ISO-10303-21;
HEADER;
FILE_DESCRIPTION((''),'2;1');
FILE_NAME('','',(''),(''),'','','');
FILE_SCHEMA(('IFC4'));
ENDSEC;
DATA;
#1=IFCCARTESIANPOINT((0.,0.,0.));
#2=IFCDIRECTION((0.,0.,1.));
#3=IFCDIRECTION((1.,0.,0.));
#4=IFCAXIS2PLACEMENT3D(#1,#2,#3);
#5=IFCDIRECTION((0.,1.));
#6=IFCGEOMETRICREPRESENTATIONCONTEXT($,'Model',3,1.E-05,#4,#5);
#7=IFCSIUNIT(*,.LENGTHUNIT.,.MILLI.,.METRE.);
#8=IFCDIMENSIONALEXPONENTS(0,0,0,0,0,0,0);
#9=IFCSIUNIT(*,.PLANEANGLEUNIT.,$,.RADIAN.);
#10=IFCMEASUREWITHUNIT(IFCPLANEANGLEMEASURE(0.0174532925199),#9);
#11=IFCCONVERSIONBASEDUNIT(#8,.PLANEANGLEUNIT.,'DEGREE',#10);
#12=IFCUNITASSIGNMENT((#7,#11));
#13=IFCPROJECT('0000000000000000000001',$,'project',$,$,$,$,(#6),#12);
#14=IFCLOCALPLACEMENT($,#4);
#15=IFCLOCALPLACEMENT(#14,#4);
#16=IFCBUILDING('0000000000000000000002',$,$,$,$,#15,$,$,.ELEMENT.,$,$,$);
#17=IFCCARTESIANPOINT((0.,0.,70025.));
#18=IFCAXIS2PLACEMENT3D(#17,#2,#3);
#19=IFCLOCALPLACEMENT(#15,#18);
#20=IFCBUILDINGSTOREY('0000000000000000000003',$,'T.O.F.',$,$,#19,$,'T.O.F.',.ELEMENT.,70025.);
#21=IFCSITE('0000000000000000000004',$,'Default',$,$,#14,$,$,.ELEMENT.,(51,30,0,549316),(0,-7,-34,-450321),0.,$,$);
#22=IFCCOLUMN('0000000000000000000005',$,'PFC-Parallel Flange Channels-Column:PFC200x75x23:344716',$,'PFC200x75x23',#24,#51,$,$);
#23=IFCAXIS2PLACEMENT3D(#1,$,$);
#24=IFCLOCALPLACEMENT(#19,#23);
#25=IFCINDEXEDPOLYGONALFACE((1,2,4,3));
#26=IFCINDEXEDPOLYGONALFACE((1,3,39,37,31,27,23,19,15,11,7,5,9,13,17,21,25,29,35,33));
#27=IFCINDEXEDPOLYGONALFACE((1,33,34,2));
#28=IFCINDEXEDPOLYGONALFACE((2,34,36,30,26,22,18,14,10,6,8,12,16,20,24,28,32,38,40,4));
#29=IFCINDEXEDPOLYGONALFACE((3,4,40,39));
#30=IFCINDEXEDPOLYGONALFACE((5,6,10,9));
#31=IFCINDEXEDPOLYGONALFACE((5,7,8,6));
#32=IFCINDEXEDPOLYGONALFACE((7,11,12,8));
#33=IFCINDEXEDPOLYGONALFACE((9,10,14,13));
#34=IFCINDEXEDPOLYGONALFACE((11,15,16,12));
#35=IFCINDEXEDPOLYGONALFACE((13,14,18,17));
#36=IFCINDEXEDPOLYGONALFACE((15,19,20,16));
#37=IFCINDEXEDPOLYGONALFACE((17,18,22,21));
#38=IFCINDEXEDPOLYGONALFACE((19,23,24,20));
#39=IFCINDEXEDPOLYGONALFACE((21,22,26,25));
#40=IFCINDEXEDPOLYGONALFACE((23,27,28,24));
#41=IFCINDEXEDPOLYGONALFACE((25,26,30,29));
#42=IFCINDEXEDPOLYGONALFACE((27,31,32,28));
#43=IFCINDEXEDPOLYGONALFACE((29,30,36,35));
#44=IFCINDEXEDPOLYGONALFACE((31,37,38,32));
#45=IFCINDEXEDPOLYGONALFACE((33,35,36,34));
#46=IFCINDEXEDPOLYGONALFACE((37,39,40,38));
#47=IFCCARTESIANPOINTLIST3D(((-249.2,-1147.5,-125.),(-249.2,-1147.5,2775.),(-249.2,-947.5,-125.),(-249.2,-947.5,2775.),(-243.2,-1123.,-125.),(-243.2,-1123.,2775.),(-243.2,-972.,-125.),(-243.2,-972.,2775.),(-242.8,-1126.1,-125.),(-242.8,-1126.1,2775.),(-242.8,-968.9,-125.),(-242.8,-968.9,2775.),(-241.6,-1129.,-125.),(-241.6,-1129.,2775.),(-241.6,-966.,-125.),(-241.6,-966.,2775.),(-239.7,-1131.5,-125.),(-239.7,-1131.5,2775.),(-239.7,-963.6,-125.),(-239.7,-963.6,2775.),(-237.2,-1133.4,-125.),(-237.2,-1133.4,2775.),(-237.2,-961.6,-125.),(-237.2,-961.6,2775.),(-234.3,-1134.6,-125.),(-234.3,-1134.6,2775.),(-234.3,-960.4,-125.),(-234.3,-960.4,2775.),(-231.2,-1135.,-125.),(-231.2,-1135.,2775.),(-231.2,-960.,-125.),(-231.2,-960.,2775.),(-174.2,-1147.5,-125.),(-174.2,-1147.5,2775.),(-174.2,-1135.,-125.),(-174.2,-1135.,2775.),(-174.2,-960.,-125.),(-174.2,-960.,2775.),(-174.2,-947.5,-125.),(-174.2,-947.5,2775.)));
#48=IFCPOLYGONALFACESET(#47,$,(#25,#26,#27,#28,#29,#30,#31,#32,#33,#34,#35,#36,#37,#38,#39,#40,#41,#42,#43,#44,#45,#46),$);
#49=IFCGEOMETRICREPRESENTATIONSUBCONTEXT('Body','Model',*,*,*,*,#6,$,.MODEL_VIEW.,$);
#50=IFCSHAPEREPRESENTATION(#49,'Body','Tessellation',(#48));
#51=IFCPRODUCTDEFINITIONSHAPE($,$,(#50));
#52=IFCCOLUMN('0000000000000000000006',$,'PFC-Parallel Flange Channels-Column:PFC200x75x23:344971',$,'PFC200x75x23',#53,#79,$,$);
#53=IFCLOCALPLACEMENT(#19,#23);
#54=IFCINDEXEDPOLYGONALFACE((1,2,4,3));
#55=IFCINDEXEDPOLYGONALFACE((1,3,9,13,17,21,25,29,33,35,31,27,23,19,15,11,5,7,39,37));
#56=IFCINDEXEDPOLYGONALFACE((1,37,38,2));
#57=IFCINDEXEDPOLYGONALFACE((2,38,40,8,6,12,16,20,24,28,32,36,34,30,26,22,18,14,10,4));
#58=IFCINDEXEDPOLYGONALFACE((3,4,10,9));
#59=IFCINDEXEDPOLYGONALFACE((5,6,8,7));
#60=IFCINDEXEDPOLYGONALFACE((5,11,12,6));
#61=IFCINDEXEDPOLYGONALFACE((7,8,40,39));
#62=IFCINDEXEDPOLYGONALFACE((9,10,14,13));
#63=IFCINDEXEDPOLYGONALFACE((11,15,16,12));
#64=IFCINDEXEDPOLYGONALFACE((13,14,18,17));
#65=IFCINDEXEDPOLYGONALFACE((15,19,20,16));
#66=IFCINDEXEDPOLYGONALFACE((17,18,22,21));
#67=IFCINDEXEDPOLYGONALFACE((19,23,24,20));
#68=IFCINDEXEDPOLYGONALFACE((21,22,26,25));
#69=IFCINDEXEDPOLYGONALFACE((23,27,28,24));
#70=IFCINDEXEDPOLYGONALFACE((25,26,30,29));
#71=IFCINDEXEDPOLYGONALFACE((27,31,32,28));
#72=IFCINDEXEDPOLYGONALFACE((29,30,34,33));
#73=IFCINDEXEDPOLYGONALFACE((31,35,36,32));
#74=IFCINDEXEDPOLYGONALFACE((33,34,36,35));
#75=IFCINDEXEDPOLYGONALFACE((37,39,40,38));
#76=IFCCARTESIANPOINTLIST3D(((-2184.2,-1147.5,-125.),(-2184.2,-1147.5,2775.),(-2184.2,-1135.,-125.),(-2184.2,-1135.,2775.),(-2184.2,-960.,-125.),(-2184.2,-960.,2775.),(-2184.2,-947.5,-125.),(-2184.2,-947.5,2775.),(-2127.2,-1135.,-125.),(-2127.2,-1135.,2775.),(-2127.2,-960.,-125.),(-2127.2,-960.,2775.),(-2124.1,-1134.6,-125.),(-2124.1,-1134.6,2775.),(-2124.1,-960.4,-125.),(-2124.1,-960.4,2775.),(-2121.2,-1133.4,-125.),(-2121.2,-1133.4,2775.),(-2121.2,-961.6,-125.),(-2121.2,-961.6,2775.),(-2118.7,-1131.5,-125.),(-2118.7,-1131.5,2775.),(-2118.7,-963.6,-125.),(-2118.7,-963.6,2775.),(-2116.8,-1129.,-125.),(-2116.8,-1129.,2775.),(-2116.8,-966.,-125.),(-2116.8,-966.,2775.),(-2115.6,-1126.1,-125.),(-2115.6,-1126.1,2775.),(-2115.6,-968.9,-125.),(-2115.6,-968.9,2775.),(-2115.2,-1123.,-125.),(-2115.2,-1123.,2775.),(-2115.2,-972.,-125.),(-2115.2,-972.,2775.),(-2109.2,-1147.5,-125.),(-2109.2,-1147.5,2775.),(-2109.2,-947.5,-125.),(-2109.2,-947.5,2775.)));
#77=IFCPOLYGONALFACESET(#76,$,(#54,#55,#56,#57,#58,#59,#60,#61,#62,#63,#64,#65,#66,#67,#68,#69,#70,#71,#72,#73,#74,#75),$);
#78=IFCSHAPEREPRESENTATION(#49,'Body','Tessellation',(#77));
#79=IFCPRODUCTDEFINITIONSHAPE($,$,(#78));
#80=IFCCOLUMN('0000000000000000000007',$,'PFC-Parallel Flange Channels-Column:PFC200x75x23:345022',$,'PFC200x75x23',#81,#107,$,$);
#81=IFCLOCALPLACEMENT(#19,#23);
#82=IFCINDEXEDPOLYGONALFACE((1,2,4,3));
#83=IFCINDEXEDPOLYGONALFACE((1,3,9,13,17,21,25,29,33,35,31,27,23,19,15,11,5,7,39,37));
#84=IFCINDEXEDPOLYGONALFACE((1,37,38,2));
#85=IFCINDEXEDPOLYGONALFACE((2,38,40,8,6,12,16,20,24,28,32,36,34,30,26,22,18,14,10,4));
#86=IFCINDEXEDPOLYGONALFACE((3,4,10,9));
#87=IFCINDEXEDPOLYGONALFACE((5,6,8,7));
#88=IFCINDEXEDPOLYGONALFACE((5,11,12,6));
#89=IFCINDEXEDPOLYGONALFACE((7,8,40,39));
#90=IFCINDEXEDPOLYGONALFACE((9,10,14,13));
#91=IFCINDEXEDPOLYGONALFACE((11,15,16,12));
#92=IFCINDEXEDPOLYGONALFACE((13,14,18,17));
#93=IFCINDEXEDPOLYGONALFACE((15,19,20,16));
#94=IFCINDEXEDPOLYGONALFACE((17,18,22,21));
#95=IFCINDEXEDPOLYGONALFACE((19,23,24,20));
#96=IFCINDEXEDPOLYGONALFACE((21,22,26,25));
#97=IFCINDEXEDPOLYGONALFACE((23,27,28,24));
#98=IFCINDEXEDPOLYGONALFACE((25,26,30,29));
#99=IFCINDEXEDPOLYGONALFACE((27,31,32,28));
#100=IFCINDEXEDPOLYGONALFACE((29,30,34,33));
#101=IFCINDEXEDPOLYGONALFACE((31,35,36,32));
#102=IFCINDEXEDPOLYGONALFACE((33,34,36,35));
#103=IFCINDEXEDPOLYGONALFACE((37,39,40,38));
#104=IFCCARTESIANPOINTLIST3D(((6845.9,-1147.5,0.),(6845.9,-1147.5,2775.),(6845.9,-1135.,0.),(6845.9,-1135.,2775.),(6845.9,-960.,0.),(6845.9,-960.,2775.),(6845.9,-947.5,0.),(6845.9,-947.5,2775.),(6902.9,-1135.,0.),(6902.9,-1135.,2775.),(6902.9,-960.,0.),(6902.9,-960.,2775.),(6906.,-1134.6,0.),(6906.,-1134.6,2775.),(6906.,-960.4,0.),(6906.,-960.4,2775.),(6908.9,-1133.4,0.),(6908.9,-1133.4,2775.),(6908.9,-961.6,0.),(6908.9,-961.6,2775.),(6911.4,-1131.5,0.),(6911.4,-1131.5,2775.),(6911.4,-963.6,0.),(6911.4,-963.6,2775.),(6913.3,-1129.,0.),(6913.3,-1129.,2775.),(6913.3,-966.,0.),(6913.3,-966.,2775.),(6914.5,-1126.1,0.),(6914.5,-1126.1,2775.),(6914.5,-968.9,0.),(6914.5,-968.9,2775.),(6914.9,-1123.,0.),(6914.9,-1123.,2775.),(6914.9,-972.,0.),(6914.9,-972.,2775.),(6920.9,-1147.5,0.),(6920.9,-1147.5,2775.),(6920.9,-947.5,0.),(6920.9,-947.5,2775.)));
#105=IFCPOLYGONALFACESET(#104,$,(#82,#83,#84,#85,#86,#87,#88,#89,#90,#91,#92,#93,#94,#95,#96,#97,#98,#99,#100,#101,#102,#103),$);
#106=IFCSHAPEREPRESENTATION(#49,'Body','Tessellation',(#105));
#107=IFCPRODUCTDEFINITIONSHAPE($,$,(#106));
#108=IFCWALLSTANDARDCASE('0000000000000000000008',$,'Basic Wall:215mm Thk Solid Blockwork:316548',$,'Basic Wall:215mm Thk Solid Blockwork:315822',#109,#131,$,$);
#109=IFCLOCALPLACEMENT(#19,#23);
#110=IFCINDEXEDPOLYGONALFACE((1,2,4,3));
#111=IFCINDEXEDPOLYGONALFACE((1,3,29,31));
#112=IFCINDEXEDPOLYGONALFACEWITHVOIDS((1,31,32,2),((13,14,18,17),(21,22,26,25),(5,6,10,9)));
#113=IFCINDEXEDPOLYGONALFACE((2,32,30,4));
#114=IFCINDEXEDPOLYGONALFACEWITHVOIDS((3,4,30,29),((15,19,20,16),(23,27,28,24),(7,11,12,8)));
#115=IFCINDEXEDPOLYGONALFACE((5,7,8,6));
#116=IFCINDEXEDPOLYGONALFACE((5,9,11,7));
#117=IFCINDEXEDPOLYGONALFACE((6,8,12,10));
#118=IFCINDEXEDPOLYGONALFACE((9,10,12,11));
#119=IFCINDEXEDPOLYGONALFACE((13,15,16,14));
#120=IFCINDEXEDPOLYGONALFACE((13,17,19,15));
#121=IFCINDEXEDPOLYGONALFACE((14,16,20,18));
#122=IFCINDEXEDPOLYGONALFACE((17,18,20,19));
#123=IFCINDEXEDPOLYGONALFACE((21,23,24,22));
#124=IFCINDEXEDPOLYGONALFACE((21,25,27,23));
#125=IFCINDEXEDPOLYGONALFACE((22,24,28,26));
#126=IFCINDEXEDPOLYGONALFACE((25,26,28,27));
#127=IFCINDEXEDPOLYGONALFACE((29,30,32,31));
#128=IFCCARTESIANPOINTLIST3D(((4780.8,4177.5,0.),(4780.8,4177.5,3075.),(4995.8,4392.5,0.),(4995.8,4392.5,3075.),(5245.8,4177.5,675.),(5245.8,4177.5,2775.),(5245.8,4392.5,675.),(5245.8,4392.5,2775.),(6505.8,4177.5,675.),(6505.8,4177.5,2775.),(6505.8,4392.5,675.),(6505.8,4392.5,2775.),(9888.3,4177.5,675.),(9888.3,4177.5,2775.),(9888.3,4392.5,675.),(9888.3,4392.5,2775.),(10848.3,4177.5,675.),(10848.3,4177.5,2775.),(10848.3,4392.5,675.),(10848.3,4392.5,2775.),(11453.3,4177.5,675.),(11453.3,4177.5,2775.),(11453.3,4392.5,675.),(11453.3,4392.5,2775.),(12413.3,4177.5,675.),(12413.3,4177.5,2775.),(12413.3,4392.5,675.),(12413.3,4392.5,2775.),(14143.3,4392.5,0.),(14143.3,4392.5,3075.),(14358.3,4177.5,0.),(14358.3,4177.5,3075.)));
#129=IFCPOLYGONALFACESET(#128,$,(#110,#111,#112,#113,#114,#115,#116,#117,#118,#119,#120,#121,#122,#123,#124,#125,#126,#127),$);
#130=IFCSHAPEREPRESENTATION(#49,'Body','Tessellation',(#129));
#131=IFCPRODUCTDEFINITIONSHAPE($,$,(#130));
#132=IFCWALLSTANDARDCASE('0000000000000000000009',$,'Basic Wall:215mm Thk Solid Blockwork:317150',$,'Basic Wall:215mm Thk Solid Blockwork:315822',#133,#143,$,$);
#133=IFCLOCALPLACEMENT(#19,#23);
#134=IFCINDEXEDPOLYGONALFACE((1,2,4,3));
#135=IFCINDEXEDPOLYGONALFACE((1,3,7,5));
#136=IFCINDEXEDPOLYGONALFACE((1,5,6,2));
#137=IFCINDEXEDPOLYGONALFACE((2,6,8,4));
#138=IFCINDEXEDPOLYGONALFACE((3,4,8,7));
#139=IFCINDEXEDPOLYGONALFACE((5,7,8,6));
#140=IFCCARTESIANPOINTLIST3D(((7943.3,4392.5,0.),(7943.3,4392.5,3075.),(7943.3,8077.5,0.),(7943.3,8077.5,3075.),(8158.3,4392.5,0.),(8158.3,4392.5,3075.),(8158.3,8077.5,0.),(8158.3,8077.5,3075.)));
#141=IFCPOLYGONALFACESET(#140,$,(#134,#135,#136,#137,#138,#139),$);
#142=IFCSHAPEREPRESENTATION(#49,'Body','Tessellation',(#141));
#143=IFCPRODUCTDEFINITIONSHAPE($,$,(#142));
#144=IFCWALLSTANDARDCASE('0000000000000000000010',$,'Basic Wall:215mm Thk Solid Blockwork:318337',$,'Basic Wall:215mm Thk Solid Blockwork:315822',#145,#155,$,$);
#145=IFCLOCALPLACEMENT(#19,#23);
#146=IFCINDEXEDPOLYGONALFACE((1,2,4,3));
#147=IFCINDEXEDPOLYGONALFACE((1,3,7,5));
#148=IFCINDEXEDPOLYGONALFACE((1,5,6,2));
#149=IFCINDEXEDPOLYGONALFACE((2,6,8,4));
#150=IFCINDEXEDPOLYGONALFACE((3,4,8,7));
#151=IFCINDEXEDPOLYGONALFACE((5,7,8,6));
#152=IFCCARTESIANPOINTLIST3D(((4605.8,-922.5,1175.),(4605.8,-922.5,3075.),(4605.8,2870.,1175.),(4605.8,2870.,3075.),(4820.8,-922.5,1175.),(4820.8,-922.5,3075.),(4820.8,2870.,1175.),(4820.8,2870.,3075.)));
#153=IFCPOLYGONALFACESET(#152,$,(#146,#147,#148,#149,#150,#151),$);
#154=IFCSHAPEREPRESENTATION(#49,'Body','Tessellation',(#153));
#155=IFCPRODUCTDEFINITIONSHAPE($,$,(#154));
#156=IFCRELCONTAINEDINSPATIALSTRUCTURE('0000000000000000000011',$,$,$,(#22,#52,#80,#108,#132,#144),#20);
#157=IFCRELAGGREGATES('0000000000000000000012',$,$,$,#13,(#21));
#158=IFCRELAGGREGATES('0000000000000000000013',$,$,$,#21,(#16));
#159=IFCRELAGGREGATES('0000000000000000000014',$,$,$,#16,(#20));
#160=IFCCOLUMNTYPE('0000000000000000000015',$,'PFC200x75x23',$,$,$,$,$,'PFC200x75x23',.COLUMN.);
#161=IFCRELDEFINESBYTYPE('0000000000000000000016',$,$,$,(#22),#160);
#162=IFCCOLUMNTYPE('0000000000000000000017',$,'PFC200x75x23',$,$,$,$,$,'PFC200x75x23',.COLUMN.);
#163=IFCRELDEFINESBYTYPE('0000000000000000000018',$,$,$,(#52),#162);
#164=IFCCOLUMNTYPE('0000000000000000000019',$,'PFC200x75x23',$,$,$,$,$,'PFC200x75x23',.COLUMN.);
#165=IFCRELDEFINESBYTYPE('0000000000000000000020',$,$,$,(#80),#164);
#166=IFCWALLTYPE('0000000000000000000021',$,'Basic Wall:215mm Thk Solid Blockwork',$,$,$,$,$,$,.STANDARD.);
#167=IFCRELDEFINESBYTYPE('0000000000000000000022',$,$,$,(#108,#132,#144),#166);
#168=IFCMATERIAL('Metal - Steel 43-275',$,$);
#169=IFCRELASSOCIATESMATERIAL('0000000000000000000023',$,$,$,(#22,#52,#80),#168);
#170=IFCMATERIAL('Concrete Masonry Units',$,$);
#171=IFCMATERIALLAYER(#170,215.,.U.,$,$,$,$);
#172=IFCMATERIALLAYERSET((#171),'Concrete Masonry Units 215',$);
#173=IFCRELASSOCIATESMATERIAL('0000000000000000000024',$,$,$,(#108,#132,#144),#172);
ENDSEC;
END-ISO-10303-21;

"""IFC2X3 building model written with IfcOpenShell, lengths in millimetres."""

from ifc_helpers import new_model, entity, si_unit, converted_unit, point, direction, frame, frame_2d, origin_with_axes, place, context, subcontext, project, spatial, polyline, circle_curve, parameter, trimmed, segment, composite_curve, outline, extrude, material, layer, layer_set, layer_usage, type_object, element, save


model = new_model("IFC2X3")

# Units and contexts
model_context = context("Model", 3, precision=1e-05, world=origin_with_axes(), true_north=direction((0.0, 1.0)))
body_context = subcontext(model_context, "Body", "Model", "MODEL_VIEW")
ifc_project = project(units=[si_unit("LENGTHUNIT", "METRE", prefix="MILLI"), converted_unit("PLANEANGLEUNIT", "DEGREE", entity("IfcPlaneAngleMeasure", 0.0174532925199), si_unit("PLANEANGLEUNIT", "RADIAN"), dimensions=[0, 0, 0, 0, 0, 0, 0])], contexts=[model_context])

# Site, building, storey
site_placement = place(None, origin_with_axes())
site = spatial("IfcSite", under=ifc_project, at=site_placement, Name="Default", CompositionType="ELEMENT", RefLatitude=(51, 30, 0, 549316), RefLongitude=(0, -7, -34, -450321), RefElevation=0.0)
building_placement = place(site_placement, origin_with_axes())
building = spatial("IfcBuilding", under=site, at=building_placement, CompositionType="ELEMENT")
storey_placement = place(building_placement, frame((0.0, 0.0, 70025.0), z_axis=(0.0, 0.0, 1.0), x_axis=(1.0, 0.0, 0.0)))
storey = spatial("IfcBuildingStorey", under=building, at=storey_placement, Name="T.O.F.", LongName="T.O.F.", CompositionType="ELEMENT", Elevation=70025.0)

# Columns
ifc_material_1 = material(Name="Metal - Steel 43-275")
column_type_1 = type_object("IfcColumnType", Name="PFC200x75x23", ElementType="PFC200x75x23", PredefinedType="COLUMN")
column_1_placement = place(storey_placement, frame((-214.4, -1047.5, -125.0), z_axis=(0.0, 0.0, 1.0), x_axis=(0.0, -1.0, 0.0)))
element("IfcColumn", 1, at=column_1_placement, inside=storey, type_object=column_type_1, material=ifc_material_1, Name="PFC-Parallel Flange Channels-Column:PFC200x75x23:344716", ObjectType="PFC200x75x23", context=body_context, shape_type="SweptSolid", body=[
    extrude(outline(composite_curve([segment(polyline([(-100.0, -34.8), (100.0, -34.8), (100.0, 40.2), (87.5, 40.2), (87.5, -16.8)]), True, "CONTINUOUS"), segment(trimmed(circle_curve(frame_2d((75.5, -16.8), x_axis=(0.0, -1.0)), 12.0), [point((87.5, -16.8)), parameter(90.0)], [point((75.5, -28.8)), parameter(0.0)], False, "CARTESIAN"), True, "CONTINUOUS"), segment(polyline([(75.5, -28.8), (-75.5, -28.8)]), True, "CONTINUOUS"), segment(trimmed(circle_curve(frame_2d((-75.5, -16.8), x_axis=(-1.0, 0.0)), 12.0), [point((-75.5, -28.8)), parameter(90.0)], [point((-87.5, -16.8)), parameter(0.0)], False, "CARTESIAN"), True, "CONTINUOUS"), segment(polyline([(-87.5, -16.8), (-87.5, 40.2), (-100.0, 40.2), (-100.0, -34.8)]), True, "CONTINUOUS")], self_intersect=False)), origin_with_axes(), (0.0, 0.0, 1.0), 2900.0),
])
column_type_2 = type_object("IfcColumnType", Name="PFC200x75x23", ElementType="PFC200x75x23", PredefinedType="COLUMN")
column_2_placement = place(storey_placement, frame((-2144.0, -1047.5, -125.0), z_axis=(0.0, 0.0, 1.0), x_axis=(0.0, 1.0, 0.0)))
element("IfcColumn", 2, at=column_2_placement, inside=storey, type_object=column_type_2, material=ifc_material_1, Name="PFC-Parallel Flange Channels-Column:PFC200x75x23:344971", ObjectType="PFC200x75x23", context=body_context, shape_type="SweptSolid", body=[
    extrude(outline(composite_curve([segment(polyline([(-100.0, -34.8), (100.0, -34.8), (100.0, 40.2), (87.5, 40.2), (87.5, -16.8)]), True, "CONTINUOUS"), segment(trimmed(circle_curve(frame_2d((75.5, -16.8), x_axis=(0.0, -1.0)), 12.0), [point((87.5, -16.8)), parameter(90.0)], [point((75.5, -28.8)), parameter(0.0)], False, "CARTESIAN"), True, "CONTINUOUS"), segment(polyline([(75.5, -28.8), (-75.5, -28.8)]), True, "CONTINUOUS"), segment(trimmed(circle_curve(frame_2d((-75.5, -16.8), x_axis=(-1.0, 0.0)), 12.0), [point((-75.5, -28.8)), parameter(90.0)], [point((-87.5, -16.8)), parameter(0.0)], False, "CARTESIAN"), True, "CONTINUOUS"), segment(polyline([(-87.5, -16.8), (-87.5, 40.2), (-100.0, 40.2), (-100.0, -34.8)]), True, "CONTINUOUS")], self_intersect=False)), origin_with_axes(), (0.0, 0.0, 1.0), 2900.0),
])
column_type_3 = type_object("IfcColumnType", Name="PFC200x75x23", ElementType="PFC200x75x23", PredefinedType="COLUMN")
column_3_placement = place(storey_placement, frame((6886.1, -1047.5, 0.0), z_axis=(0.0, 0.0, 1.0), x_axis=(0.0, 1.0, 0.0)))
element("IfcColumn", 3, at=column_3_placement, inside=storey, type_object=column_type_3, material=ifc_material_1, Name="PFC-Parallel Flange Channels-Column:PFC200x75x23:345022", ObjectType="PFC200x75x23", context=body_context, shape_type="SweptSolid", body=[
    extrude(outline(composite_curve([segment(polyline([(-100.0, -34.8), (100.0, -34.8), (100.0, 40.2), (87.5, 40.2), (87.5, -16.8)]), True, "CONTINUOUS"), segment(trimmed(circle_curve(frame_2d((75.5, -16.8), x_axis=(0.0, -1.0)), 12.0), [point((87.5, -16.8)), parameter(90.0)], [point((75.5, -28.8)), parameter(0.0)], False, "CARTESIAN"), True, "CONTINUOUS"), segment(polyline([(75.5, -28.8), (-75.5, -28.8)]), True, "CONTINUOUS"), segment(trimmed(circle_curve(frame_2d((-75.5, -16.8), x_axis=(-1.0, 0.0)), 12.0), [point((-75.5, -28.8)), parameter(90.0)], [point((-87.5, -16.8)), parameter(0.0)], False, "CARTESIAN"), True, "CONTINUOUS"), segment(polyline([(-87.5, -16.8), (-87.5, 40.2), (-100.0, 40.2), (-100.0, -34.8)]), True, "CONTINUOUS")], self_intersect=False)), origin_with_axes(), (0.0, 0.0, 1.0), 2775.0),
])

# Shared definitions
ifc_material_2 = material(Name="Concrete Masonry Units")
ifc_layer_1 = layer(ifc_material_2, 215.0, ventilated="UNKNOWN")
ifc_layer_set_1 = layer_set([ifc_layer_1], Name="Concrete Masonry Units 215")
wall_type_1 = type_object("IfcWallType", Name="Basic Wall:215mm Thk Solid Blockwork", PredefinedType="STANDARD")

# Wall, openings
ifc_layer_usage_1 = layer_usage(ifc_layer_set_1, "AXIS2", "POSITIVE", -107.5)
wall_1_placement = place(storey_placement, frame((4888.3, 4285.0, 0.0), z_axis=(0.0, 0.0, 1.0), x_axis=(1.0, 0.0, 0.0)))
wall_1 = element("IfcWallStandardCase", 4, at=wall_1_placement, inside=storey, type_object=wall_type_1, material=ifc_layer_usage_1, Name="Basic Wall:215mm Thk Solid Blockwork:316548", ObjectType="Basic Wall:215mm Thk Solid Blockwork:315822", context=body_context, shape_type="SweptSolid", body=[
    extrude(outline(polyline([(-107.5, -107.5), (9470.0, -107.5), (9255.0, 107.5), (107.5, 107.5), (-107.5, -107.5)])), origin_with_axes(), (0.0, 0.0, 1.0), 3075.0),
])
opening_1_placement = place(wall_1_placement, frame((987.5, 0.0, 675.0), z_axis=(0.0, 0.0, 1.0), x_axis=(1.0, 0.0, 0.0)))
element("IfcOpeningElement", 5, at=opening_1_placement, cuts=wall_1, context=body_context, shape_type="SweptSolid", body=[
    extrude(outline(polyline([(630.0, 0.0), (-630.0, 0.0), (-630.0, -2100.0), (630.0, -2100.0), (630.0, 0.0)])), frame((0.0, -107.5, 0.0), z_axis=(0.0, -1.0, 0.0), x_axis=(-1.0, 0.0, 0.0)), (0.0, 0.0, -1.0), 215.0),
])
opening_2_placement = place(wall_1_placement, frame((7045.0, 0.0, 675.0), z_axis=(0.0, 0.0, 1.0), x_axis=(1.0, 0.0, 0.0)))
element("IfcOpeningElement", 6, at=opening_2_placement, cuts=wall_1, context=body_context, shape_type="SweptSolid", body=[
    extrude(outline(polyline([(480.0, 0.0), (-480.0, 0.0), (-480.0, -2100.0), (480.0, -2100.0), (480.0, 0.0)])), frame((0.0, -107.5, 0.0), z_axis=(0.0, -1.0, 0.0), x_axis=(-1.0, 0.0, 0.0)), (0.0, 0.0, -1.0), 215.0),
])
opening_3_placement = place(wall_1_placement, frame((5480.0, 0.0, 675.0), z_axis=(0.0, 0.0, 1.0), x_axis=(1.0, 0.0, 0.0)))
element("IfcOpeningElement", 7, at=opening_3_placement, cuts=wall_1, context=body_context, shape_type="SweptSolid", body=[
    extrude(outline(polyline([(-480.0, 0.0), (-480.0, -2100.0), (480.0, -2100.0), (480.0, 0.0), (-480.0, 0.0)])), frame((0.0, -107.5, 0.0), z_axis=(0.0, 1.0, 0.0), x_axis=(1.0, 0.0, 0.0)), (0.0, 0.0, 1.0), 215.0),
])

# Walls
ifc_layer_usage_2 = layer_usage(ifc_layer_set_1, "AXIS2", "POSITIVE", -107.5)
wall_2_placement = place(storey_placement, frame((8050.8, 4285.0, 0.0), z_axis=(0.0, 0.0, 1.0), x_axis=(0.0, 1.0, 0.0)))
element("IfcWallStandardCase", 8, at=wall_2_placement, inside=storey, type_object=wall_type_1, material=ifc_layer_usage_2, Name="Basic Wall:215mm Thk Solid Blockwork:317150", ObjectType="Basic Wall:215mm Thk Solid Blockwork:315822", context=body_context, shape_type="SweptSolid", body=[
    extrude(outline(polyline([(107.5, -107.5), (3792.5, -107.5), (3792.5, 107.5), (107.5, 107.5), (107.5, -107.5)])), origin_with_axes(), (0.0, 0.0, 1.0), 3075.0),
])
ifc_layer_usage_3 = layer_usage(ifc_layer_set_1, "AXIS2", "POSITIVE", -107.5)
wall_3_placement = place(storey_placement, frame((4713.3, 2870.0, 1175.0), z_axis=(0.0, 0.0, 1.0), x_axis=(0.0, -1.0, 0.0)))
element("IfcWallStandardCase", 9, at=wall_3_placement, inside=storey, type_object=wall_type_1, material=ifc_layer_usage_3, Name="Basic Wall:215mm Thk Solid Blockwork:318337", ObjectType="Basic Wall:215mm Thk Solid Blockwork:315822", context=body_context, shape_type="SweptSolid", body=[
    extrude(outline(polyline([(0.0, -107.5), (3792.5, -107.5), (3792.5, 107.5), (0.0, 107.5), (0.0, -107.5)])), origin_with_axes(), (0.0, 0.0, 1.0), 1900.0),
])

save(model, "model.ifc")
